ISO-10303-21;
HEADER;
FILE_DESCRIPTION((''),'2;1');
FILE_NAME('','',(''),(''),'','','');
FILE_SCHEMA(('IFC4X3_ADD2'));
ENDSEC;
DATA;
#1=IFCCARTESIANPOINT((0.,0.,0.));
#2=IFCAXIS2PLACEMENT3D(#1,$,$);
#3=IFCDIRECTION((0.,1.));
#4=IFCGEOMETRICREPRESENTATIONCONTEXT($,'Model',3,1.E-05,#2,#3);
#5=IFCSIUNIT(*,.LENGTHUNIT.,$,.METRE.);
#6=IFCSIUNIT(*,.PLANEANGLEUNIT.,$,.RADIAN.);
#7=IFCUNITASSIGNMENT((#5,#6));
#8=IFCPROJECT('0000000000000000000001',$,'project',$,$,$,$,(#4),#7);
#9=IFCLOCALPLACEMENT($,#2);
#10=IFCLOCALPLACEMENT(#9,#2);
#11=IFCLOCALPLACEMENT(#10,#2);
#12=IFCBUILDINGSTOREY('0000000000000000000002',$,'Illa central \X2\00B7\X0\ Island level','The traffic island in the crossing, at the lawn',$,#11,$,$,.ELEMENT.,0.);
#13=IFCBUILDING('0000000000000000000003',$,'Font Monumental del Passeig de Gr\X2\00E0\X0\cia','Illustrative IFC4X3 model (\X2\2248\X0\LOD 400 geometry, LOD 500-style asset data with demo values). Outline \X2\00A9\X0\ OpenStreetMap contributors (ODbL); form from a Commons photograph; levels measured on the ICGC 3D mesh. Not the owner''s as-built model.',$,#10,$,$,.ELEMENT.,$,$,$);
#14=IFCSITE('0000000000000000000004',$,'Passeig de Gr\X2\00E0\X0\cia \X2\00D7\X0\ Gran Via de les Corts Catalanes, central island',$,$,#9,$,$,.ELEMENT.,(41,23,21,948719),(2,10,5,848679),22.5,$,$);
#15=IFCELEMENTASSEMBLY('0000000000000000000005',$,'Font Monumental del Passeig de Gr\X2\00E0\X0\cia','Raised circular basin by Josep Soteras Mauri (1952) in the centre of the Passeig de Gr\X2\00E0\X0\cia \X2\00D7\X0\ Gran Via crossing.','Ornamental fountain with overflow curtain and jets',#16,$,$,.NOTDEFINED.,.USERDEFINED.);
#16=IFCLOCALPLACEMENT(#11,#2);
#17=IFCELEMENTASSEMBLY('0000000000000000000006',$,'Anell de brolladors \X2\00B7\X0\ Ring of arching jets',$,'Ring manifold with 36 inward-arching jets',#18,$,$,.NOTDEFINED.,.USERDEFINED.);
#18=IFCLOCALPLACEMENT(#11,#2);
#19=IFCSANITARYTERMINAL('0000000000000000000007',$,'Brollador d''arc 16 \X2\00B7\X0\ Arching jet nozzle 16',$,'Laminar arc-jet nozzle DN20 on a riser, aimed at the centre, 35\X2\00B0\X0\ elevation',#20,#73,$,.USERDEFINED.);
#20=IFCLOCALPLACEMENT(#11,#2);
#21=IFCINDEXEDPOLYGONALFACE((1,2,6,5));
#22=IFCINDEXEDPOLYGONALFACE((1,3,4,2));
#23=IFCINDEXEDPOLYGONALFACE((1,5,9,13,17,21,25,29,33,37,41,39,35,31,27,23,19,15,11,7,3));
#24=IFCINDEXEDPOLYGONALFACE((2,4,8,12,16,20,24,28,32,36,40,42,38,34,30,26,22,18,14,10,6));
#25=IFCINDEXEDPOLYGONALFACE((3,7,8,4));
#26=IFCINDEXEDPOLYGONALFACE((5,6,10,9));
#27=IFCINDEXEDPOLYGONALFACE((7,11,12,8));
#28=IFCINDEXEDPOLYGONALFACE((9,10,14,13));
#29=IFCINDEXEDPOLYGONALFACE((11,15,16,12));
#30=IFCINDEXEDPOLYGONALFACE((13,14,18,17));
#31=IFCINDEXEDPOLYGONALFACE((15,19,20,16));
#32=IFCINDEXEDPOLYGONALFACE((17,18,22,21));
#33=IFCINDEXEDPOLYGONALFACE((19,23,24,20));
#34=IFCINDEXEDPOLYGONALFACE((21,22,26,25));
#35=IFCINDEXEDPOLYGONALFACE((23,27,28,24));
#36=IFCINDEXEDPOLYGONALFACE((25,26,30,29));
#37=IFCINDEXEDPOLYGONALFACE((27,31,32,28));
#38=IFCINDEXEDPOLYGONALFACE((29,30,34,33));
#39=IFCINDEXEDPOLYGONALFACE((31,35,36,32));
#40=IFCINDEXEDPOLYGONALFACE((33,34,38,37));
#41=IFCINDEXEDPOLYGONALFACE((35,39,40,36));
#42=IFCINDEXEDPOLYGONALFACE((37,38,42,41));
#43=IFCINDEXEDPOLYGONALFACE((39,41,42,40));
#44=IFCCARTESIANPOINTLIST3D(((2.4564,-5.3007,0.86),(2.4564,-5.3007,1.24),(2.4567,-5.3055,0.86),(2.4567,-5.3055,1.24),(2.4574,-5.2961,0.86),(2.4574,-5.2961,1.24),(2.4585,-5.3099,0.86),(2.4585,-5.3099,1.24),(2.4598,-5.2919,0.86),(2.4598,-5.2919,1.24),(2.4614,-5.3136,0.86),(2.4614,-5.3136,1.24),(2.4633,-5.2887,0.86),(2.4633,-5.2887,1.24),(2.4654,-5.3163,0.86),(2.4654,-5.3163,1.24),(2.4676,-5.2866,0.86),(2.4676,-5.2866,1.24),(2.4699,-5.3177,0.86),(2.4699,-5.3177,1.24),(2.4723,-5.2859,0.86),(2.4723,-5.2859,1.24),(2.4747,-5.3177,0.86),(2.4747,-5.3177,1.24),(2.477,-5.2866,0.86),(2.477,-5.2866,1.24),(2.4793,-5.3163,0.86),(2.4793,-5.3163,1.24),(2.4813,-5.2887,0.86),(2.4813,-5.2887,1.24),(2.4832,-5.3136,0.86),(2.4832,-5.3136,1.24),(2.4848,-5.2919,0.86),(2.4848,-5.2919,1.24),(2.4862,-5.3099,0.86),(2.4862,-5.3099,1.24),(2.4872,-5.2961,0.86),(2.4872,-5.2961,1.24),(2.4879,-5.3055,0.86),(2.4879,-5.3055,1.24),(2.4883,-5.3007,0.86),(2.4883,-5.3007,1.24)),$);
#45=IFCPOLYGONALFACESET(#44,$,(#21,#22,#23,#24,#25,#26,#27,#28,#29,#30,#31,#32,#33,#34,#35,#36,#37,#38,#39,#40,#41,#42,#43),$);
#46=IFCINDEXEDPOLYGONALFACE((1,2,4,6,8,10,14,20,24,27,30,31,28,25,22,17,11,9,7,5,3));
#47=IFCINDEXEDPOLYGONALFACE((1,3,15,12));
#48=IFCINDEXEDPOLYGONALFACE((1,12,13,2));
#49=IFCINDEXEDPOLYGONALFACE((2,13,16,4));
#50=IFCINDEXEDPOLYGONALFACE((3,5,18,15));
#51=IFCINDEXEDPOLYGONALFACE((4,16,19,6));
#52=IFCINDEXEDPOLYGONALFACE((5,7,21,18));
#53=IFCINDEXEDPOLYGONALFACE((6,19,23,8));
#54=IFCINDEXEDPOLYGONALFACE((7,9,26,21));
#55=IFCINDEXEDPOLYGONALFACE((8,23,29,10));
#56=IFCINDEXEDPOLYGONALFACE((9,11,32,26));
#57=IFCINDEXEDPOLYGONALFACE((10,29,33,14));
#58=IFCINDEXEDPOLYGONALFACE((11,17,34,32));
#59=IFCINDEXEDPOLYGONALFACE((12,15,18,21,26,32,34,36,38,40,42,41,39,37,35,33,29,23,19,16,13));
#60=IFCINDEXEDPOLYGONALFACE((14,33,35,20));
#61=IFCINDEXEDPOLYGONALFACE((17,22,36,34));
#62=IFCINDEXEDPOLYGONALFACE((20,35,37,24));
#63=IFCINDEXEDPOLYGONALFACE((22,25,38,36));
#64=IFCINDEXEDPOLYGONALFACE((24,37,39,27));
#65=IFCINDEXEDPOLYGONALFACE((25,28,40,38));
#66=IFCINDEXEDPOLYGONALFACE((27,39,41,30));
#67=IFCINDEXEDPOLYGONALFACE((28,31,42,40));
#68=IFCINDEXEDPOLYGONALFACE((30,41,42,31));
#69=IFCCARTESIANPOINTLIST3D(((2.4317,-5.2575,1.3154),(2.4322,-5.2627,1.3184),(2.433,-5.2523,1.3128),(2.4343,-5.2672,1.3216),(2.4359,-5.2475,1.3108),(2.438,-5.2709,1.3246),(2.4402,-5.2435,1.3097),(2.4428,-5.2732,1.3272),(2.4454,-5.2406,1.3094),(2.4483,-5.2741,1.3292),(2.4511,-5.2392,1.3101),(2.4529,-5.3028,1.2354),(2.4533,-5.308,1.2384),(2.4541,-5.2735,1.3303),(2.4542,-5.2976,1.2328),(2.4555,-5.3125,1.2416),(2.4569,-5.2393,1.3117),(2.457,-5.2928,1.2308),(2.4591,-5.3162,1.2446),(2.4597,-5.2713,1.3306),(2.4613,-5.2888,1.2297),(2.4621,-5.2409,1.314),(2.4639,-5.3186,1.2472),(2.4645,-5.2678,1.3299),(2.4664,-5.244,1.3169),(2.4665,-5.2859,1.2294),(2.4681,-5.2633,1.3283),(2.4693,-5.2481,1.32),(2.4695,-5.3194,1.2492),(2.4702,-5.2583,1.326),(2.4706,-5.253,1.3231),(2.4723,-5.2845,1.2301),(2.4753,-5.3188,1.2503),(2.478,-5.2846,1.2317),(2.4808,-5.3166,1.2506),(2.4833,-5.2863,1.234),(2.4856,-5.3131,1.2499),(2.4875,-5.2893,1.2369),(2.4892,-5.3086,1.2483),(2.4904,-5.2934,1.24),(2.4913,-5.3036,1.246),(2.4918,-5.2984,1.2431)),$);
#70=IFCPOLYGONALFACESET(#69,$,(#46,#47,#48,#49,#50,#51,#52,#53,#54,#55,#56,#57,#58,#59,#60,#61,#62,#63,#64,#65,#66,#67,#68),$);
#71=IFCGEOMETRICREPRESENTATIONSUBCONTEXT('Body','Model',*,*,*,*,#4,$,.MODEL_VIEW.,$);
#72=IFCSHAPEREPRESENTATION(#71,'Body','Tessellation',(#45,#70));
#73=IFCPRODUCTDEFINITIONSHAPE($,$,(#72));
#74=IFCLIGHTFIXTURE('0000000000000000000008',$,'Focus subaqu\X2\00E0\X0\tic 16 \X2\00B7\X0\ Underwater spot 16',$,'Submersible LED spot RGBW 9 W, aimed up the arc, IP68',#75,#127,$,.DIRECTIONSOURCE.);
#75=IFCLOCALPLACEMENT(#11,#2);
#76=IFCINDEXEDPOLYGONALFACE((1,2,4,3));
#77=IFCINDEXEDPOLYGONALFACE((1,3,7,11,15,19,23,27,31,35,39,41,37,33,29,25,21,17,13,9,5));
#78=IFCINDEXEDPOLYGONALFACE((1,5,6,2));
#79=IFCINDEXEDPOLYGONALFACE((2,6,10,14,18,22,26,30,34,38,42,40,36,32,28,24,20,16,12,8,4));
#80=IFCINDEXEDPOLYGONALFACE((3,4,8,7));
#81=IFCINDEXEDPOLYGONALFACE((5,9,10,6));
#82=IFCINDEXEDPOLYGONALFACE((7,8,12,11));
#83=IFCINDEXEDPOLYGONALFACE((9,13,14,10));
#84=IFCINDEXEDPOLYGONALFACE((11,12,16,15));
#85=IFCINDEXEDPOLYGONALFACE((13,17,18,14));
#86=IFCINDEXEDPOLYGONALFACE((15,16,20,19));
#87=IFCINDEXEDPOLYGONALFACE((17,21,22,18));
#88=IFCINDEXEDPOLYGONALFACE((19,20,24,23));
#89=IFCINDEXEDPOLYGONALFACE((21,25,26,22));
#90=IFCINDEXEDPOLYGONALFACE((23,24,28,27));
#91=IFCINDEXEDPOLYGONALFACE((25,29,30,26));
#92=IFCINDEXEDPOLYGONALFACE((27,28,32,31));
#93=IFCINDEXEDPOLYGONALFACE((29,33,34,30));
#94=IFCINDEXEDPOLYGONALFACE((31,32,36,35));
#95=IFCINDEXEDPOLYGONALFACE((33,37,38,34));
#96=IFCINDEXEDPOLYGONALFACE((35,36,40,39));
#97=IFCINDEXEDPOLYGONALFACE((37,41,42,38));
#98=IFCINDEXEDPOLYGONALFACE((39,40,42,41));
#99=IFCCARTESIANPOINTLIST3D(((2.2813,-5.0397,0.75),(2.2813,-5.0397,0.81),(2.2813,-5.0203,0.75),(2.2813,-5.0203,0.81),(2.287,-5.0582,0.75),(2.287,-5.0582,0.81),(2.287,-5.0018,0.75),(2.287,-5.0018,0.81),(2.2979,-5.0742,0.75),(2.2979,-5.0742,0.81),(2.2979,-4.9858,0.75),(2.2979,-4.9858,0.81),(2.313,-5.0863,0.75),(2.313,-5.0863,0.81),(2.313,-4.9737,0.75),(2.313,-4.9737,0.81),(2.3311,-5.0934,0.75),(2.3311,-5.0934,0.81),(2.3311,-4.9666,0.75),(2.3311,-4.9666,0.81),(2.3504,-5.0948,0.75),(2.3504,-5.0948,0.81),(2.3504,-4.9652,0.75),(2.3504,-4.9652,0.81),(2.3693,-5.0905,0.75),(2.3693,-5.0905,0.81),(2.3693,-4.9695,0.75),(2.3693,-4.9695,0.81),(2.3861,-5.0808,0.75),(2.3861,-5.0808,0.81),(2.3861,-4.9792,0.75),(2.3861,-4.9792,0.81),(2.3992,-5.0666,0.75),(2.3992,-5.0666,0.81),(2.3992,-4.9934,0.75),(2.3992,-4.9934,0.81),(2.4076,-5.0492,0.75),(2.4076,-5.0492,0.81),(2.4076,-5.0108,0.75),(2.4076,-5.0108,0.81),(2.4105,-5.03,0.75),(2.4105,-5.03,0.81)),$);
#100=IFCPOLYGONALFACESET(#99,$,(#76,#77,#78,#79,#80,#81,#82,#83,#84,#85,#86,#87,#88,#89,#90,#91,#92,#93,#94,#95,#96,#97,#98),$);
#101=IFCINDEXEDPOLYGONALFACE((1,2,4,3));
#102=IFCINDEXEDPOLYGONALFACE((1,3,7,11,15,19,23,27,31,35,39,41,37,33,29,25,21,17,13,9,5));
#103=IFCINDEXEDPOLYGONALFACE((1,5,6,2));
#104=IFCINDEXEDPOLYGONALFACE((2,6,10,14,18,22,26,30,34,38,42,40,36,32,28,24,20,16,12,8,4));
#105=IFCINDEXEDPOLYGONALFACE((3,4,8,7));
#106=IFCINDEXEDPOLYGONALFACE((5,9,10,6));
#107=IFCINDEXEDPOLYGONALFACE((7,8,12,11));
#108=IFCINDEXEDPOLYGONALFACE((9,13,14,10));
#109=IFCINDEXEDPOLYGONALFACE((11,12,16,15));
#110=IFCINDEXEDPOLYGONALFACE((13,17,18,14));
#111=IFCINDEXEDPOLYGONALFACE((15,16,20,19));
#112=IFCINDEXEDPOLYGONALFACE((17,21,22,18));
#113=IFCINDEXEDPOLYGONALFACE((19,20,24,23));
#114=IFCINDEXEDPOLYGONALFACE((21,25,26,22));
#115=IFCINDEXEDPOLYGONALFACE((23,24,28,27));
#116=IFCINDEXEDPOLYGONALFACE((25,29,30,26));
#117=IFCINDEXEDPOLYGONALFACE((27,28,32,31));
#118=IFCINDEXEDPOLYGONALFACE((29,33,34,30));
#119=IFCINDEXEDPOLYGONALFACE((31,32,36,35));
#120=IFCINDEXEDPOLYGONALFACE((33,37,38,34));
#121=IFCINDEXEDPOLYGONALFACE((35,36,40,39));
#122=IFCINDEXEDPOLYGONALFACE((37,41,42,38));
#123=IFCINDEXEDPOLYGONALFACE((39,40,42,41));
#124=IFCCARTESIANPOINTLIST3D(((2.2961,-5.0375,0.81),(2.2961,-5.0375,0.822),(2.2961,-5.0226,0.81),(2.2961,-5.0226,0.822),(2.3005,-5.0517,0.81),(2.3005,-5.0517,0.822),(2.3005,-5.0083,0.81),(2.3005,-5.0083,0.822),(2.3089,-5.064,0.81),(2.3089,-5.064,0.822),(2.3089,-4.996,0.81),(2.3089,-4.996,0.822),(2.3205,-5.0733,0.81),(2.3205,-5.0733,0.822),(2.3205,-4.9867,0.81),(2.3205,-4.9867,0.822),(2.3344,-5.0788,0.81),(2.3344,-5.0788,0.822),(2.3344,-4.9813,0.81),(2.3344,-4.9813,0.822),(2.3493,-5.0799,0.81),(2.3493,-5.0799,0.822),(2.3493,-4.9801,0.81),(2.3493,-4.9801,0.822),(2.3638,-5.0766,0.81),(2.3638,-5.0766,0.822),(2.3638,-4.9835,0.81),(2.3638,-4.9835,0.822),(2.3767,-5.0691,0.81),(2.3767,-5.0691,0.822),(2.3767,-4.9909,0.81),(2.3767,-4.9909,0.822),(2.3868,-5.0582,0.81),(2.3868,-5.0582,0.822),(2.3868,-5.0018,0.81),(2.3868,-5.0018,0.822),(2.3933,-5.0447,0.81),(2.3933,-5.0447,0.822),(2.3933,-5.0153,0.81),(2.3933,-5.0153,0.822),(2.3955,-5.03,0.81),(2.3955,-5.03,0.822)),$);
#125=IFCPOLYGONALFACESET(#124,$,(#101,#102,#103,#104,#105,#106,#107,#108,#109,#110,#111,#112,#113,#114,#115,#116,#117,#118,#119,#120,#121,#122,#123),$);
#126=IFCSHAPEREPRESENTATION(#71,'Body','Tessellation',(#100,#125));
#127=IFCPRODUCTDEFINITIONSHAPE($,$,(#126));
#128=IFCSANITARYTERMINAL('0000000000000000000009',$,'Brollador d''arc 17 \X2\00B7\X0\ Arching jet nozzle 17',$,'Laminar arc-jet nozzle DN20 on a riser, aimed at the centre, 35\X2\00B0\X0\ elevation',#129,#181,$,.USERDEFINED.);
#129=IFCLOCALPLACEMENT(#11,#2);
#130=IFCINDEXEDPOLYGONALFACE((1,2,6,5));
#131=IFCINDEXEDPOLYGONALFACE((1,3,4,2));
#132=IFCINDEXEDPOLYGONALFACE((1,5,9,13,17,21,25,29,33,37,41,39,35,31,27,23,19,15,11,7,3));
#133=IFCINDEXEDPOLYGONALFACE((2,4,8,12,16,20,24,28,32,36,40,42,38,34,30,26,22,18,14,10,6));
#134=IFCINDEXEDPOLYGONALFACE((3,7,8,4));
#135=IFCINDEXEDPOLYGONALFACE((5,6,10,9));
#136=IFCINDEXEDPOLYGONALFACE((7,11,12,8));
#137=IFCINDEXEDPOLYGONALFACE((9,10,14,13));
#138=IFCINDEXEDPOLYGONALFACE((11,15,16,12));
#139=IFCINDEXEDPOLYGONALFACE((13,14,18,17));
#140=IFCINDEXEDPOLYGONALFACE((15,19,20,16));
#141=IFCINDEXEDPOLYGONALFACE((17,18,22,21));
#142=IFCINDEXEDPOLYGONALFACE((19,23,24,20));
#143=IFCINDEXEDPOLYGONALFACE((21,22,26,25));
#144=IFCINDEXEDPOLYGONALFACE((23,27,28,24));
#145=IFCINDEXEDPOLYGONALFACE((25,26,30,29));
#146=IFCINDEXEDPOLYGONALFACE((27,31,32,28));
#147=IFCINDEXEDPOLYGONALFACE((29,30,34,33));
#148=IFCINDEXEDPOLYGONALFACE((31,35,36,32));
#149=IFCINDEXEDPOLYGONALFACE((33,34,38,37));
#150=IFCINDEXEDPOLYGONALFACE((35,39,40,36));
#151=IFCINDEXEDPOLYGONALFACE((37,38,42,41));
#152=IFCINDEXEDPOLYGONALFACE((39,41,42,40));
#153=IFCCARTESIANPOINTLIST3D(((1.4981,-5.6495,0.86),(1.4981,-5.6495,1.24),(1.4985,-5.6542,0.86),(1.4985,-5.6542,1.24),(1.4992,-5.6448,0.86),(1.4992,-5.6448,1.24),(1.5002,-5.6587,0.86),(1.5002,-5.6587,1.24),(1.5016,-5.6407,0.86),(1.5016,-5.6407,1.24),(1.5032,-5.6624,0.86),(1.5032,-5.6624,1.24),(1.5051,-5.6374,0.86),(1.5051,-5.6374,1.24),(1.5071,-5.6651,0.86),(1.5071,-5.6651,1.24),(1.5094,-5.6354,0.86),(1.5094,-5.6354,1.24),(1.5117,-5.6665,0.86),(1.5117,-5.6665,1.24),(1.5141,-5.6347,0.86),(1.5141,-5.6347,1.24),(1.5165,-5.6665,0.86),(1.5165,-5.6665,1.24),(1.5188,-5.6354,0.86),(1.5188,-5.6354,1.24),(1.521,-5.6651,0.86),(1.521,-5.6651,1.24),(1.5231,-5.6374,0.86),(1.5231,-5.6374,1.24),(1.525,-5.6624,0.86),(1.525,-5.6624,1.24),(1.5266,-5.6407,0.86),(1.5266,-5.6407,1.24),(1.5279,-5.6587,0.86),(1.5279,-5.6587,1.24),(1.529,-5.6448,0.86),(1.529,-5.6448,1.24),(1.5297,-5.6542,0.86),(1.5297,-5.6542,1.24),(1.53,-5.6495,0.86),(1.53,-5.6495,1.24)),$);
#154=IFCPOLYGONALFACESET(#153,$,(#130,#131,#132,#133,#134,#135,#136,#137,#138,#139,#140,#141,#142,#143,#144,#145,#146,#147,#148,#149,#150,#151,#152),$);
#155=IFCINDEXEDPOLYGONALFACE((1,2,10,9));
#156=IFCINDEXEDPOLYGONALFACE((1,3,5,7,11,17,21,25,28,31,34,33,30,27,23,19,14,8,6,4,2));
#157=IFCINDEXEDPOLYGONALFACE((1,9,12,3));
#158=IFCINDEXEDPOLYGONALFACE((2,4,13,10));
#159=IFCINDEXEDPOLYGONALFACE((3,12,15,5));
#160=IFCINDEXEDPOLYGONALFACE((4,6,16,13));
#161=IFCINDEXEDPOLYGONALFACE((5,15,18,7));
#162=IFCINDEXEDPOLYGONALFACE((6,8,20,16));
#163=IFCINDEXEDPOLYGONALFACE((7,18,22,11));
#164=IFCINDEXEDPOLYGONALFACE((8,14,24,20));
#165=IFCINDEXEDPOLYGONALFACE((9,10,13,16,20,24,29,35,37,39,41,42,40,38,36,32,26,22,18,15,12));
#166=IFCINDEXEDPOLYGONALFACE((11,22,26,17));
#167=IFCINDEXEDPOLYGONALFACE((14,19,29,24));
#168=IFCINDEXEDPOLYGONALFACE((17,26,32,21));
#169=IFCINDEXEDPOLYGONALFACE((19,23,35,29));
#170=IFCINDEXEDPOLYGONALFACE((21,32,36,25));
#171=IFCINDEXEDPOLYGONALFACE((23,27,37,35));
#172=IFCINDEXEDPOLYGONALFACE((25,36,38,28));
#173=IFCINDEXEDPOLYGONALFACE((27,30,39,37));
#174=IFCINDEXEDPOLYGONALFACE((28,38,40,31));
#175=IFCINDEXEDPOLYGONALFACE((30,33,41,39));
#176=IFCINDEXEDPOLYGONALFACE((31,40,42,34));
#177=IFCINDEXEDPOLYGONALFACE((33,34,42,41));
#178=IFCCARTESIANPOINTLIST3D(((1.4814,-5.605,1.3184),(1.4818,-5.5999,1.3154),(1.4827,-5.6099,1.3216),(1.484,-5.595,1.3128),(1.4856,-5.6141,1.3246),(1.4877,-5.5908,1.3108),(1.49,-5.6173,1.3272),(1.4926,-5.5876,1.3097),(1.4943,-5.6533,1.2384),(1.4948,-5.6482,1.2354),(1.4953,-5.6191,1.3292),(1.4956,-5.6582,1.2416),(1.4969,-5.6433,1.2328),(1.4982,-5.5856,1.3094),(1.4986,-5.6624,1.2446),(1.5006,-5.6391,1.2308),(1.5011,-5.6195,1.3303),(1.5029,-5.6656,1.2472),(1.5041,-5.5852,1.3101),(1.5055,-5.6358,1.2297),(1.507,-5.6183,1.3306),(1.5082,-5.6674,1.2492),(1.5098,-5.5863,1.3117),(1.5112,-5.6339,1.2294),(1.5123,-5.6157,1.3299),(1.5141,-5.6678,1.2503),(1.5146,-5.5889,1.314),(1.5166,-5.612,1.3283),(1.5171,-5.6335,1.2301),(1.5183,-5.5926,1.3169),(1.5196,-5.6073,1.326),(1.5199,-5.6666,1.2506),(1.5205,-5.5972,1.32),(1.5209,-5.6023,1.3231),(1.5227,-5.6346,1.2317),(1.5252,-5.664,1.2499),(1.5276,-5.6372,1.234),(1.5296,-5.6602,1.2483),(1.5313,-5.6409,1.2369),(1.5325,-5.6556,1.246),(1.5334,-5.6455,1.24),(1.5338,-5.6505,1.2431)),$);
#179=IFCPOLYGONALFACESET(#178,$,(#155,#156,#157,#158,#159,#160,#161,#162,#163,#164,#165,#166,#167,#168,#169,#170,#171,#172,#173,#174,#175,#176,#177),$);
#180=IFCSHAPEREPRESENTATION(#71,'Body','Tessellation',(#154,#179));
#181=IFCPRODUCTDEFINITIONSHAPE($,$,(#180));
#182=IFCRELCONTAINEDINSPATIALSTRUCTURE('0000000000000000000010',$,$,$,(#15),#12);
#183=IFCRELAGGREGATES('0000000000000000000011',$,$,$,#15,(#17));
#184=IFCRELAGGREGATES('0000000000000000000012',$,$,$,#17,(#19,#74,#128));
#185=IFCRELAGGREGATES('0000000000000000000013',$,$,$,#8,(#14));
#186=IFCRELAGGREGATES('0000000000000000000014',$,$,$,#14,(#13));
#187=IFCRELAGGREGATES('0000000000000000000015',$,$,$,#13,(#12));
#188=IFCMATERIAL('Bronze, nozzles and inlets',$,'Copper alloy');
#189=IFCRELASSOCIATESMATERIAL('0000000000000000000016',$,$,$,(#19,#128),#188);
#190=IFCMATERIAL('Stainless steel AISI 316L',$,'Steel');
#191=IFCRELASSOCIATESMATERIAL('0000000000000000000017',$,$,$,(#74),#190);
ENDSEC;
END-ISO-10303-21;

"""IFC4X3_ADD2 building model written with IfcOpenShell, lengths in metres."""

from ifc_helpers import new_model, si_unit, direction, frame, origin, origin_2d_with_axis, place, context, subcontext, project, spatial, circle, extrude, material, element, aggregate, save


model = new_model("IFC4X3_ADD2")

# Units and contexts
model_context = context("Model", 3, precision=1e-05, world=origin(), true_north=direction((0.0, 1.0)))
body_context = subcontext(model_context, "Body", "Model", "MODEL_VIEW")
ifc_project = project(units=[si_unit("LENGTHUNIT", "METRE"), si_unit("PLANEANGLEUNIT", "RADIAN")], contexts=[model_context])

# Site, building, storey
site_placement = place(None, origin())
site = spatial("IfcSite", under=ifc_project, at=site_placement, Name="Passeig de Gràcia × Gran Via de les Corts Catalanes, central island", CompositionType="ELEMENT", RefLatitude=(41, 23, 21, 948719), RefLongitude=(2, 10, 5, 848679), RefElevation=22.5)
building_placement = place(site_placement, origin())
building = spatial("IfcBuilding", under=site, at=building_placement, Name="Font Monumental del Passeig de Gràcia", Description="Illustrative IFC4X3 model (≈LOD 400 geometry, LOD 500-style asset data with demo values). Outline © OpenStreetMap contributors (ODbL); form from a Commons photograph; levels measured on the ICGC 3D mesh. Not the owner's as-built model.", CompositionType="ELEMENT")
storey_placement = place(building_placement, origin())
storey = spatial("IfcBuildingStorey", under=building, at=storey_placement, Name="Illa central · Island level", Description="The traffic island in the crossing, at the lawn", CompositionType="ELEMENT", Elevation=0.0)

# Element assemblies, sanitary terminals, light fixture
assembly_1_placement = place(building_placement, origin())
assembly_1 = element("IfcElementAssembly", 1, at=assembly_1_placement, inside=storey, Name="Font Monumental del Passeig de Gràcia", Description="Raised circular basin by Josep Soteras Mauri (1952) in the centre of the Passeig de Gràcia × Gran Via crossing.", ObjectType="Ornamental fountain with overflow curtain and jets", AssemblyPlace="NOTDEFINED", PredefinedType="USERDEFINED")
assembly_2_placement = place(building_placement, origin())
assembly_2 = element("IfcElementAssembly", 2, at=assembly_2_placement, Name="Anell de brolladors · Ring of arching jets", ObjectType="Ring manifold with 36 inward-arching jets", AssemblyPlace="NOTDEFINED", PredefinedType="USERDEFINED")
aggregate(assembly_1, [assembly_2])
ifc_material_1 = material(Name="Bronze, nozzles and inlets", Category="Copper alloy")
ifc_material_2 = material(Name="Stainless steel AISI 316L", Category="Steel")
sanitary_terminal_1_placement = place(building_placement, origin())
sanitary_terminal_1 = element("IfcSanitaryTerminal", 3, at=sanitary_terminal_1_placement, material=ifc_material_1, Name="Brollador d'arc 16 · Arching jet nozzle 16", ObjectType="Laminar arc-jet nozzle DN20 on a riser, aimed at the centre, 35° elevation", PredefinedType="USERDEFINED", context=body_context, shape_type="SweptSolid", body=[
    extrude(circle(Radius=0.016, at=origin_2d_with_axis()), frame((2.4723, -5.3019, 0.86), z_axis=(0.0, 0.0, 1.0), x_axis=(0.0, 1.0, 0.0)), (0.0, 0.0, 1.0), 0.38),
    extrude(circle(Radius=0.02, at=origin_2d_with_axis()), frame((2.4723, -5.3019, 1.24), z_axis=(-0.223987, 0.480342, 0.847998), x_axis=(0.906308, 0.422618, 0.0)), (0.0, 0.0, 1.0), 0.0943),
])
light_fixture_1_placement = place(building_placement, origin())
light_fixture_1 = element("IfcLightFixture", 4, at=light_fixture_1_placement, material=ifc_material_2, Name="Focus subaquàtic 16 · Underwater spot 16", ObjectType="Submersible LED spot RGBW 9 W, aimed up the arc, IP68", PredefinedType="DIRECTIONSOURCE", context=body_context, shape_type="SweptSolid", body=[
    extrude(circle(Radius=0.065, at=origin_2d_with_axis()), frame((2.3455, -5.03, 0.75)), (0.0, 0.0, 1.0), 0.06),
    extrude(circle(Radius=0.05, at=origin_2d_with_axis()), frame((2.3455, -5.03, 0.81)), (0.0, 0.0, 1.0), 0.012),
])
sanitary_terminal_2_placement = place(building_placement, origin())
sanitary_terminal_2 = element("IfcSanitaryTerminal", 5, at=sanitary_terminal_2_placement, material=ifc_material_1, Name="Brollador d'arc 17 · Arching jet nozzle 17", ObjectType="Laminar arc-jet nozzle DN20 on a riser, aimed at the centre, 35° elevation", PredefinedType="USERDEFINED", context=body_context, shape_type="SweptSolid", body=[
    extrude(circle(Radius=0.016, at=origin_2d_with_axis()), frame((1.5141, -5.6507, 0.86), z_axis=(0.0, 0.0, 1.0), x_axis=(0.0, 1.0, 0.0)), (0.0, 0.0, 1.0), 0.38),
    extrude(circle(Radius=0.02, at=origin_2d_with_axis()), frame((1.5141, -5.6507, 1.24), z_axis=(-0.137174, 0.51194, 0.847998), x_axis=(0.965926, 0.258819, 0.0)), (0.0, 0.0, 1.0), 0.0943),
])
aggregate(assembly_2, [sanitary_terminal_1, light_fixture_1, sanitary_terminal_2])

save(model, "model.ifc")
